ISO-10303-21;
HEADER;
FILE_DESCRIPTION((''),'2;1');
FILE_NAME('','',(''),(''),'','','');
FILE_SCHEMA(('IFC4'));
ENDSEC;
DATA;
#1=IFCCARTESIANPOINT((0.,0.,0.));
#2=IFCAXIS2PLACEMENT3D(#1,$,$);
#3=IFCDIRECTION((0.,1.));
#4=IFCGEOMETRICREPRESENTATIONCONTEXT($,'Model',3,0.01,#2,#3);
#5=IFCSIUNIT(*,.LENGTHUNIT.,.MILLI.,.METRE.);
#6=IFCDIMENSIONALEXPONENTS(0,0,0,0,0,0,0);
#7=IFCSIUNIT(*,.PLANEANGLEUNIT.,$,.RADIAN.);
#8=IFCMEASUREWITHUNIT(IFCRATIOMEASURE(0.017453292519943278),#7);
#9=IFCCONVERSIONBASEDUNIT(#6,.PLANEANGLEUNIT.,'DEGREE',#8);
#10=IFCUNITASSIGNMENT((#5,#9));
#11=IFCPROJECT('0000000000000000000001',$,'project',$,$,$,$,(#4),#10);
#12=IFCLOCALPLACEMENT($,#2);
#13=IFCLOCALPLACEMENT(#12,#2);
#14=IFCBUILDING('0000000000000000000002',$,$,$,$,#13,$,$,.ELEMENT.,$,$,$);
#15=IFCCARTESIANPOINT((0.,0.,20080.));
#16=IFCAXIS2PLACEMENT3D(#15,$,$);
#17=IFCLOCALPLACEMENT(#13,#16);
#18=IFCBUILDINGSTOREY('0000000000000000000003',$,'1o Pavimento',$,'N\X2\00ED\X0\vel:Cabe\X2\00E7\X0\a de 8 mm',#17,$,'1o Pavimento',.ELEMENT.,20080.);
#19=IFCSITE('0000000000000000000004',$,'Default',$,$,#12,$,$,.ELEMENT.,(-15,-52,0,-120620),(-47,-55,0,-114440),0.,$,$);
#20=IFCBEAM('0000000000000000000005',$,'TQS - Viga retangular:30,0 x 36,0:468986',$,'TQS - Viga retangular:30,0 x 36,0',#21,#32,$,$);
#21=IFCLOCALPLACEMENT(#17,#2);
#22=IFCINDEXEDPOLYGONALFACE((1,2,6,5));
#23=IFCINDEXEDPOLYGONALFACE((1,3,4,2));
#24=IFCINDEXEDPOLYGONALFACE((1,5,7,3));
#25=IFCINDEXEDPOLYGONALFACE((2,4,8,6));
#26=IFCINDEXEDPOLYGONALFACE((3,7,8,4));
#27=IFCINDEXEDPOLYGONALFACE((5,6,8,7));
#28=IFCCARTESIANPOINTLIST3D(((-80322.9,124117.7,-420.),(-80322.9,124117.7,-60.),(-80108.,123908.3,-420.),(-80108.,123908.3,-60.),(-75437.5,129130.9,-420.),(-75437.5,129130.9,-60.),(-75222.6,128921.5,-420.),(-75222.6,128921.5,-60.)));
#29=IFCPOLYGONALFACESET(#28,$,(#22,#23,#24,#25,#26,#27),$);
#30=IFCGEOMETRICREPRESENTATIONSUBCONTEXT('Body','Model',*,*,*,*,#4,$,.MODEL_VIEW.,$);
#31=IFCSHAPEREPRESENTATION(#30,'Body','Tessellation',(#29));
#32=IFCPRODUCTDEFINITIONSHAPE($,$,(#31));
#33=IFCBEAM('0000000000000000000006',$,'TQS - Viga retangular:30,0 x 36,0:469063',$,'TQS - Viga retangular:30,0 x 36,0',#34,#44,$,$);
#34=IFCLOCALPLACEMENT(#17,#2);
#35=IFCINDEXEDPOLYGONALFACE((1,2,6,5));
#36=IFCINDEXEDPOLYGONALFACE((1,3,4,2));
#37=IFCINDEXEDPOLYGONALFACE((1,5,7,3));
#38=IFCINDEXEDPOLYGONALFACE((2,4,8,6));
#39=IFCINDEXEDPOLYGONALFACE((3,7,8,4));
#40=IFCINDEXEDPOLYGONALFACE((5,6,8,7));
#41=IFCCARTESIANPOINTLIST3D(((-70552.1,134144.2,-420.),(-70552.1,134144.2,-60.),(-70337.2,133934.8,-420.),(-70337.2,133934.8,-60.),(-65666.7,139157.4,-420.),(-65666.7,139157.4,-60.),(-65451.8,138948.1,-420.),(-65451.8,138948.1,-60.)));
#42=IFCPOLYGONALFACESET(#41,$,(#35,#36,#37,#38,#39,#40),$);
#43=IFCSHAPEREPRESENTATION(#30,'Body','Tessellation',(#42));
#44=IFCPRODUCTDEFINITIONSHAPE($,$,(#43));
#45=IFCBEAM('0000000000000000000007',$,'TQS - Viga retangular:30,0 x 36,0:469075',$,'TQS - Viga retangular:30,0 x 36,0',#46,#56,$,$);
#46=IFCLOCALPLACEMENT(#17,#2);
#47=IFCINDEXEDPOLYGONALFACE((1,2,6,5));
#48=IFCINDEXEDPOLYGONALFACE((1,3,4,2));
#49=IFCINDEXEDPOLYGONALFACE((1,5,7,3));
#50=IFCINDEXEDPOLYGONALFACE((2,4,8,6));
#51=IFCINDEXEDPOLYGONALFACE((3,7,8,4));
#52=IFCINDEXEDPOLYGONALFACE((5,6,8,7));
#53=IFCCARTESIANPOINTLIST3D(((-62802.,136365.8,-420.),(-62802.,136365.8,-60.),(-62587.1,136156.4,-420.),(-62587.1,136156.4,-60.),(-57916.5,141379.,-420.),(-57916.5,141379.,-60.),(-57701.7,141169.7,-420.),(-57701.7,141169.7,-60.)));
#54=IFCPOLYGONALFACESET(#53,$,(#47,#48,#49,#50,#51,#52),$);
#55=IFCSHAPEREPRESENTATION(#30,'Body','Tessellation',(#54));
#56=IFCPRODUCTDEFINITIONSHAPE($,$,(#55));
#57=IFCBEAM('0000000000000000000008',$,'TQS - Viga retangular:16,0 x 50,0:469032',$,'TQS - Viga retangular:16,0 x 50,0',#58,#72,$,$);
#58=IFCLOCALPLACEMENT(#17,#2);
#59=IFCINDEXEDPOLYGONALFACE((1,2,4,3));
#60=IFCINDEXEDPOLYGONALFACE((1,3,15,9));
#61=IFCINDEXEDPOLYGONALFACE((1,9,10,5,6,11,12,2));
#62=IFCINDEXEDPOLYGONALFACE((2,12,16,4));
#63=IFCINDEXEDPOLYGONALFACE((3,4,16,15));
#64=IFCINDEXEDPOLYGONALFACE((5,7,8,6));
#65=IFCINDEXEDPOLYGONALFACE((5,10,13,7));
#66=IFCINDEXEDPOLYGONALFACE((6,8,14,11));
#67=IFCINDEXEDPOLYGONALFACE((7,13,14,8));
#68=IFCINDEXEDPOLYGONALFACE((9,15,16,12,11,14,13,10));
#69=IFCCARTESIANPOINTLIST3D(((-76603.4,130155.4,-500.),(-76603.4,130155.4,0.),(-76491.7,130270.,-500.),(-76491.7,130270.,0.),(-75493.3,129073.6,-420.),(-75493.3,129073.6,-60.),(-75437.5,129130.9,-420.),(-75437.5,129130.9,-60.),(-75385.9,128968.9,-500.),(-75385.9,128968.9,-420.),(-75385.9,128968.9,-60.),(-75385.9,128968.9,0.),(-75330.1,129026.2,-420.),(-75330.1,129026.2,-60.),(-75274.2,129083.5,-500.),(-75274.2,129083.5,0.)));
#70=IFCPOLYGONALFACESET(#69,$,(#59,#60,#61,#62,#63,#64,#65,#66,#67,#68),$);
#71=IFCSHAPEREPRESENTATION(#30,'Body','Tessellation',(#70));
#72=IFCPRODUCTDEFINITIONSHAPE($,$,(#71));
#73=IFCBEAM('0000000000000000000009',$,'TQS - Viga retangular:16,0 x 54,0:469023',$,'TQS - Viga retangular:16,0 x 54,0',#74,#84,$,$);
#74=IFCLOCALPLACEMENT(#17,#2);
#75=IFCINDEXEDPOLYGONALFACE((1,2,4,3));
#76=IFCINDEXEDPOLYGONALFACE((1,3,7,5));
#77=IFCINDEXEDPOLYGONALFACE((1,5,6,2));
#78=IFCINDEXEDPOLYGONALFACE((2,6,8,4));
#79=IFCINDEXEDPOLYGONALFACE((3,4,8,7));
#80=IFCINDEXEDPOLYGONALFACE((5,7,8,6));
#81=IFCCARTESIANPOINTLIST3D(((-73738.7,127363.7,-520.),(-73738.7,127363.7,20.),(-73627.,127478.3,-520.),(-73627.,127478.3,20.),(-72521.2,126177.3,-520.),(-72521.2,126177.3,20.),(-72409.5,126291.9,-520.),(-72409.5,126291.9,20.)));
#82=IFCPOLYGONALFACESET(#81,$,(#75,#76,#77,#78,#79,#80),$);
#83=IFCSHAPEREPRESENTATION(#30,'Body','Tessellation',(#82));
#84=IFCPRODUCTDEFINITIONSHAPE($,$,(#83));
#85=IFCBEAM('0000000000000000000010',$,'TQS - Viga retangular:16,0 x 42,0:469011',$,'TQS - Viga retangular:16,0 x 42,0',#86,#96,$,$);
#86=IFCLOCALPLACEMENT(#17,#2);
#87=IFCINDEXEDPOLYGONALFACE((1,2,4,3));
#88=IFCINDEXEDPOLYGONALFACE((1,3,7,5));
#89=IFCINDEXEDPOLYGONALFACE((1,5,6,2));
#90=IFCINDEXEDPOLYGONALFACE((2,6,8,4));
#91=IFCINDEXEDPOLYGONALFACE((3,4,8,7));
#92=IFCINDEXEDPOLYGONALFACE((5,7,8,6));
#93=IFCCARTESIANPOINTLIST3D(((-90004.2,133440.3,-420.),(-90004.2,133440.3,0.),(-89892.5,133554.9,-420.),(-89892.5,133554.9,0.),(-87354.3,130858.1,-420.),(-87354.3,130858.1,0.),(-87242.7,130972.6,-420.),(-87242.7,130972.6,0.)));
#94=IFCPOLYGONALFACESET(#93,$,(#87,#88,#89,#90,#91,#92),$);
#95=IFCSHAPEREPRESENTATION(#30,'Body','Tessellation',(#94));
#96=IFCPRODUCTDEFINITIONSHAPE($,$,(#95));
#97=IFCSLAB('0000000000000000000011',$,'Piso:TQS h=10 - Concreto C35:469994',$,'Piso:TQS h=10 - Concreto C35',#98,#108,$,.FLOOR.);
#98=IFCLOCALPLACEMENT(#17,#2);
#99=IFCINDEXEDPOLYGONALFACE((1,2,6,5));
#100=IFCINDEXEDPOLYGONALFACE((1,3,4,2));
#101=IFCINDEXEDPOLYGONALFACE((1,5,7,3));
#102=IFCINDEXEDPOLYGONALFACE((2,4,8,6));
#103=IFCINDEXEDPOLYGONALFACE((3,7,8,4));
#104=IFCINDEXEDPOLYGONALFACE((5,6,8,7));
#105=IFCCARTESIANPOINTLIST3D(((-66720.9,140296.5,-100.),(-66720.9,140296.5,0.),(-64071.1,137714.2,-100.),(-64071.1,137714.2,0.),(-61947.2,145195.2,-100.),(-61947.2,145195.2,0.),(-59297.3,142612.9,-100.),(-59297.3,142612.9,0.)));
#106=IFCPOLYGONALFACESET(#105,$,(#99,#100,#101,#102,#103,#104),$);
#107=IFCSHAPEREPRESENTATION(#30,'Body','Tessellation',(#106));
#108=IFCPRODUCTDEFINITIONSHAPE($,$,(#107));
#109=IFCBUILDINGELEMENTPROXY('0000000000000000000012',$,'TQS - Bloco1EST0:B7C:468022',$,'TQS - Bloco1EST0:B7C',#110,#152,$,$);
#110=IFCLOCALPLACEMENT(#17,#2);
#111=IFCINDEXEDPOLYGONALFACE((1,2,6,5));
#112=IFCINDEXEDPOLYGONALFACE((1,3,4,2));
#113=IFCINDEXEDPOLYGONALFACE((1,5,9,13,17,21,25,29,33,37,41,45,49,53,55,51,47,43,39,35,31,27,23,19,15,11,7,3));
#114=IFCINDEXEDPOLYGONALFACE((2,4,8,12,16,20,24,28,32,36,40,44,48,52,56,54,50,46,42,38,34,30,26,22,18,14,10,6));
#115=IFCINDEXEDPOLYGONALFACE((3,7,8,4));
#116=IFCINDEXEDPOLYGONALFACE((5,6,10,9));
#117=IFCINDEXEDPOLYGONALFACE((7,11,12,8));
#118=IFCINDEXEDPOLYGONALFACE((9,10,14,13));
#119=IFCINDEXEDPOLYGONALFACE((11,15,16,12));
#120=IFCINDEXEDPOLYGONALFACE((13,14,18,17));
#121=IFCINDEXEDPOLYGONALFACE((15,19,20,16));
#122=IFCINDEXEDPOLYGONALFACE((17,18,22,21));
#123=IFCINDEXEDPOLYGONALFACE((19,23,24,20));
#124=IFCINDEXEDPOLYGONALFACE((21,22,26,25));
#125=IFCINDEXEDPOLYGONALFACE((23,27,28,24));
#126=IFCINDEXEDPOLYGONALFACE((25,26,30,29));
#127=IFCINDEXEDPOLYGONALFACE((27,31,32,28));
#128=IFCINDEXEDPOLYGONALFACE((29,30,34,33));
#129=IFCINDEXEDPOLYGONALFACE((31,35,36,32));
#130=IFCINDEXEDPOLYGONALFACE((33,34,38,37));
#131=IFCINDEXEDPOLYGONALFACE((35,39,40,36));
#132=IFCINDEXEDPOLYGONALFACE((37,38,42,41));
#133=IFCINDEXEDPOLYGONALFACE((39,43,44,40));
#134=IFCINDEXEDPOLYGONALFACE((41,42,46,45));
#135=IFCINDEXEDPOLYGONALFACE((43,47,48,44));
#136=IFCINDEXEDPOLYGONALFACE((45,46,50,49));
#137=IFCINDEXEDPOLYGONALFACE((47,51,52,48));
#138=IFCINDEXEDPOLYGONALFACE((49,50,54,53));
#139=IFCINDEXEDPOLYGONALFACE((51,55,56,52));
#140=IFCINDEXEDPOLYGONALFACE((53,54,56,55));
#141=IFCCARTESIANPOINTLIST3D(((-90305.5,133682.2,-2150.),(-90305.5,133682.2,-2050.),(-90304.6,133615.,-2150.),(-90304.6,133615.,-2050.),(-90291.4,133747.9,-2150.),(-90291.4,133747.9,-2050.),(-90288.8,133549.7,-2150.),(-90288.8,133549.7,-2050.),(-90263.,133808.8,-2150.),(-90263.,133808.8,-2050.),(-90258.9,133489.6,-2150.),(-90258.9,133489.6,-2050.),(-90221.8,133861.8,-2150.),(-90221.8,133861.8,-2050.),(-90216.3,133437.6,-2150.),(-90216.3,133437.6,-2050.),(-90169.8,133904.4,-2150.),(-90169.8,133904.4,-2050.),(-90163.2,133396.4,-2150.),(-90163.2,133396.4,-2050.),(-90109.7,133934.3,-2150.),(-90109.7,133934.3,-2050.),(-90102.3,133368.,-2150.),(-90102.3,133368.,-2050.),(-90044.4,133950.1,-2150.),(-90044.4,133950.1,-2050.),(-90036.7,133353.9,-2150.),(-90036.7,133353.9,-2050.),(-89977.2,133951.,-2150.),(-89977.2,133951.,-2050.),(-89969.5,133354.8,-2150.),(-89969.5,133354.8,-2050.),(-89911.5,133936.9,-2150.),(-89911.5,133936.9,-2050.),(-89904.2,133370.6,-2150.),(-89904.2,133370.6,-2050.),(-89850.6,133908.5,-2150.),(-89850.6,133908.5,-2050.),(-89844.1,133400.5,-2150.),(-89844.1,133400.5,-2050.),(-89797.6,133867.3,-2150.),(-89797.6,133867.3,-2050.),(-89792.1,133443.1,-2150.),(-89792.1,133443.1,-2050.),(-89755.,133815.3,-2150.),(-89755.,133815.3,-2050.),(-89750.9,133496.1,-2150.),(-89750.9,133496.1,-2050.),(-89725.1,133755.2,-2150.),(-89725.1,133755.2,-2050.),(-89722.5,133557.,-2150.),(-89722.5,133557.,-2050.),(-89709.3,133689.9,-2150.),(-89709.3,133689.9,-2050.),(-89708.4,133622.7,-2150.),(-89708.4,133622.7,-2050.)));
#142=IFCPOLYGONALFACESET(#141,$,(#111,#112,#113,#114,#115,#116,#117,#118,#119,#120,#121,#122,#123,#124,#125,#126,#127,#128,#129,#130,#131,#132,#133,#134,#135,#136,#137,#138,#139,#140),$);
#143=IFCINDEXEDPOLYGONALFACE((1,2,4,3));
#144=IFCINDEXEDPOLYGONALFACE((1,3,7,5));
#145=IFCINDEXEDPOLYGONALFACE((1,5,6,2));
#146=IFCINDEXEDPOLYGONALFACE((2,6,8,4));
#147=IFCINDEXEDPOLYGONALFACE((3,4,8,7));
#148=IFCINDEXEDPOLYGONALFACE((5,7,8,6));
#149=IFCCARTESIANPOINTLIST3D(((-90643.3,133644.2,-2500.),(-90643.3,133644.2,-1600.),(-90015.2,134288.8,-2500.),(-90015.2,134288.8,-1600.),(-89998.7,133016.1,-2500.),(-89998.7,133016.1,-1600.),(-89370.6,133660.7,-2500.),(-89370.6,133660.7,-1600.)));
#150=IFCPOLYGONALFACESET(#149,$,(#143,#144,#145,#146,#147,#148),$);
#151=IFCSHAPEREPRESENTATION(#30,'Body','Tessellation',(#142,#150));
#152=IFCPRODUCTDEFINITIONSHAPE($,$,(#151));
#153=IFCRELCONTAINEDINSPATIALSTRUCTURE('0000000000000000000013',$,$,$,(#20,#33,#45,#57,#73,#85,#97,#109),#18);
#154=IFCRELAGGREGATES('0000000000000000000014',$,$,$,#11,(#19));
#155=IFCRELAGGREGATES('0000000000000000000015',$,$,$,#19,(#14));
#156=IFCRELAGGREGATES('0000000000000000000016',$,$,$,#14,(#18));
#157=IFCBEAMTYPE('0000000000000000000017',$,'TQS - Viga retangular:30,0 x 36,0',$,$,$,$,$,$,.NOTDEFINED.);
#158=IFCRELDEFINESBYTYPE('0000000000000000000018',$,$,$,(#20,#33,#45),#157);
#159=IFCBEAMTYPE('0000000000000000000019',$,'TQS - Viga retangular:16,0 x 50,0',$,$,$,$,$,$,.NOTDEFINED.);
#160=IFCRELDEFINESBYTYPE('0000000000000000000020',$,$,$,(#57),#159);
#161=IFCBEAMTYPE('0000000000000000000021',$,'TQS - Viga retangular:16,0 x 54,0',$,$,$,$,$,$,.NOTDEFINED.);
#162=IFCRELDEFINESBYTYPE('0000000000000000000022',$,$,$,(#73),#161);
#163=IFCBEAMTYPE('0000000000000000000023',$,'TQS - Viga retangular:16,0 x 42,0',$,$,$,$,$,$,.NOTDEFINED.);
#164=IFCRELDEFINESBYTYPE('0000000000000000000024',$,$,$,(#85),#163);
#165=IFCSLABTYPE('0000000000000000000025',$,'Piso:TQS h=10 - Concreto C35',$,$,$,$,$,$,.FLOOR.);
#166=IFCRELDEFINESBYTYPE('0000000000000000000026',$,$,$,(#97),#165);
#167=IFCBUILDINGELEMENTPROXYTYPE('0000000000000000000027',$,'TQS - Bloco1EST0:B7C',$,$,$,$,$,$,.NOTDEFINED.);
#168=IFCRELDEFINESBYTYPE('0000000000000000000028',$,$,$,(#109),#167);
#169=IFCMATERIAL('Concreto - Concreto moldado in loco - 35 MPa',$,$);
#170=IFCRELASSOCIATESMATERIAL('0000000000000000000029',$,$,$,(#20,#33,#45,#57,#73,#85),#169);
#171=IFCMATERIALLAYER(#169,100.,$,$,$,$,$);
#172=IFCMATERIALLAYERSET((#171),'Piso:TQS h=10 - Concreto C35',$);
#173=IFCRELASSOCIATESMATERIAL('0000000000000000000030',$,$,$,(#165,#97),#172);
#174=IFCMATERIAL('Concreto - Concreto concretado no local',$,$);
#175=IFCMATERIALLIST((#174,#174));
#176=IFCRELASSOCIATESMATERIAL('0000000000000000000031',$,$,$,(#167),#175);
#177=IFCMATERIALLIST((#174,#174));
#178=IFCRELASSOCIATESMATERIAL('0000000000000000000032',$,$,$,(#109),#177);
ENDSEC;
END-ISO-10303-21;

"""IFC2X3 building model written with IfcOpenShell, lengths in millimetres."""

from ifc_helpers import new_model, entity, si_unit, converted_unit, direction, frame, frame_2d, origin, origin_2d_with_axis, place, context, subcontext, project, spatial, polyline, rectangle, circle, extrude, boolean, clip, bounded_halfspace, source, transform, mapped, material, material_list, layer, layer_set, layer_usage, type_object, type_shapes, element, save


model = new_model("IFC2X3")

# Units and contexts
model_context = context("Model", 3, precision=0.01, world=origin(), true_north=direction((0.0, 1.0)))
body_context = subcontext(model_context, "Body", "Model", "MODEL_VIEW")
ifc_project = project(units=[si_unit("LENGTHUNIT", "METRE", prefix="MILLI"), converted_unit("PLANEANGLEUNIT", "DEGREE", entity("IfcRatioMeasure", 0.017453292519943278), si_unit("PLANEANGLEUNIT", "RADIAN"), dimensions=[0, 0, 0, 0, 0, 0, 0])], contexts=[model_context])

# Site, building, storey
site_placement = place(None, origin())
site = spatial("IfcSite", under=ifc_project, at=site_placement, Name="Default", CompositionType="ELEMENT", RefLatitude=(-15, -52, 0, -120620), RefLongitude=(-47, -55, 0, -114440), RefElevation=0.0)
building_placement = place(site_placement, origin())
building = spatial("IfcBuilding", under=site, at=building_placement, CompositionType="ELEMENT")
storey_placement = place(building_placement, frame((0.0, 0.0, 20080.0)))
storey = spatial("IfcBuildingStorey", under=building, at=storey_placement, Name="1o Pavimento", ObjectType="Nível:Cabeça de 8 mm", LongName="1o Pavimento", CompositionType="ELEMENT", Elevation=20080.0)

# Beams
ifc_material_1 = material(Name="Concreto - Concreto moldado in loco - 35 MPa")
beam_type_1 = type_object("IfcBeamType", Name="TQS - Viga retangular:30,0 x 36,0", PredefinedType="NOTDEFINED")
beam_1_placement = place(storey_placement, frame((-80215.5, 124013.0, -60.0), z_axis=(0.0, 0.0, 1.0), x_axis=(0.697915, 0.71618, 0.0)))
element("IfcBeam", 1, at=beam_1_placement, inside=storey, type_object=beam_type_1, material=ifc_material_1, Name="TQS - Viga retangular:30,0 x 36,0:468986", ObjectType="TQS - Viga retangular:30,0 x 36,0", context=body_context, shape_type="SweptSolid", body=[
    extrude(rectangle(XDim=360.0, YDim=300.0, at=frame_2d((0.0, 0.0), x_axis=(1.0, 0.0))), frame((0.0, 0.0, -180.0), z_axis=(1.0, 0.0, 0.0), x_axis=(0.0, 0.0, -1.0)), (0.0, 0.0, 1.0), 7000.0),
])
beam_2_placement = place(storey_placement, frame((-70444.7, 134039.5, -60.0), z_axis=(0.0, 0.0, 1.0), x_axis=(0.697915, 0.71618, 0.0)))
element("IfcBeam", 2, at=beam_2_placement, inside=storey, type_object=beam_type_1, material=ifc_material_1, Name="TQS - Viga retangular:30,0 x 36,0:469063", ObjectType="TQS - Viga retangular:30,0 x 36,0", context=body_context, shape_type="SweptSolid", body=[
    extrude(rectangle(XDim=360.0, YDim=300.0, at=frame_2d((0.0, 0.0), x_axis=(1.0, 0.0))), frame((0.0, 0.0, -180.0), z_axis=(1.0, 0.0, 0.0), x_axis=(0.0, 0.0, -1.0)), (0.0, 0.0, 1.0), 7000.0),
])
beam_3_placement = place(storey_placement, frame((-62694.5, 136261.1, -60.0), z_axis=(0.0, 0.0, 1.0), x_axis=(0.697915, 0.71618, 0.0)))
element("IfcBeam", 3, at=beam_3_placement, inside=storey, type_object=beam_type_1, material=ifc_material_1, Name="TQS - Viga retangular:30,0 x 36,0:469075", ObjectType="TQS - Viga retangular:30,0 x 36,0", context=body_context, shape_type="SweptSolid", body=[
    extrude(rectangle(XDim=360.0, YDim=300.0, at=frame_2d((0.0, 0.0), x_axis=(1.0, 0.0))), frame((0.0, 0.0, -180.0), z_axis=(1.0, 0.0, 0.0), x_axis=(0.0, 0.0, -1.0)), (0.0, 0.0, 1.0), 7000.0),
])
beam_type_2 = type_object("IfcBeamType", Name="TQS - Viga retangular:16,0 x 50,0", PredefinedType="NOTDEFINED")
beam_4_placement = place(storey_placement, frame((-75330.1, 129026.2, 0.0), z_axis=(0.0, 0.0, 1.0), x_axis=(-0.71618, 0.697915, 0.0)))
element("IfcBeam", 4, at=beam_4_placement, inside=storey, type_object=beam_type_2, material=ifc_material_1, Name="TQS - Viga retangular:16,0 x 50,0:469032", ObjectType="TQS - Viga retangular:16,0 x 50,0", context=body_context, shape_type="SweptSolid", body=[
    boolean("DIFFERENCE", clip(extrude(rectangle(XDim=500.0, YDim=160.0, at=frame_2d((0.0, 0.0), x_axis=(1.0, 0.0))), frame((0.0, 0.0, -250.0), z_axis=(1.0, 0.0, 0.0), x_axis=(0.0, 0.0, -1.0)), (0.0, 0.0, 1.0), 1700.0), bounded_halfspace(frame((150.0, 0.0, -420.0), z_axis=(-1.0, 0.0, 0.0), x_axis=(0.0, 1.0, 0.0)), False, frame((0.0, 0.0, -250.0), z_axis=(1.0, 0.0, 0.0), x_axis=(0.0, 0.0, -1.0)), polyline([(170.0, 0.0), (-190.0, 0.0), (-190.0, 80.0), (-90.0, 80.0), (170.0, 80.0), (170.0, 0.0)]))), extrude(rectangle(XDim=360.0, YDim=80.0, at=frame_2d((0.0, 0.0), x_axis=(0.0, 1.0))), frame((0.0, 40.0, -240.0), z_axis=(-1.0, 0.0, 0.0), x_axis=(0.0, -1.0, 0.0)), (0.0, 0.0, -1.0), 150.0)),
])
beam_type_3 = type_object("IfcBeamType", Name="TQS - Viga retangular:16,0 x 54,0", PredefinedType="NOTDEFINED")
beam_5_placement = place(storey_placement, frame((-72465.3, 126234.6, 20.0), z_axis=(0.0, 0.0, 1.0), x_axis=(-0.71618, 0.697915, 0.0)))
element("IfcBeam", 5, at=beam_5_placement, inside=storey, type_object=beam_type_3, material=ifc_material_1, Name="TQS - Viga retangular:16,0 x 54,0:469023", ObjectType="TQS - Viga retangular:16,0 x 54,0", context=body_context, shape_type="SweptSolid", body=[
    extrude(rectangle(XDim=540.0, YDim=160.0, at=frame_2d((0.0, 0.0), x_axis=(1.0, 0.0))), frame((0.0, 0.0, -270.0), z_axis=(1.0, 0.0, 0.0), x_axis=(0.0, 0.0, -1.0)), (0.0, 0.0, 1.0), 1700.0),
])
beam_type_4 = type_object("IfcBeamType", Name="TQS - Viga retangular:16,0 x 42,0", PredefinedType="NOTDEFINED")
beam_6_placement = place(storey_placement, frame((-87241.2, 130859.5, 0.0), z_axis=(0.0, 0.0, 1.0), x_axis=(-0.71618, 0.697915, 0.0)))
element("IfcBeam", 6, at=beam_6_placement, inside=storey, type_object=beam_type_4, material=ifc_material_1, Name="TQS - Viga retangular:16,0 x 42,0:469011", ObjectType="TQS - Viga retangular:16,0 x 42,0", context=body_context, shape_type="SweptSolid", body=[
    extrude(rectangle(XDim=420.0, YDim=160.0, at=frame_2d((0.0, 0.0), x_axis=(1.0, 0.0))), frame((80.0, 0.0, -210.0), z_axis=(1.0, 0.0, 0.0), x_axis=(0.0, 0.0, -1.0)), (0.0, 0.0, 1.0), 3700.0),
])

# Slab
ifc_layer = layer(ifc_material_1, 100.0)
ifc_layer_set = layer_set([ifc_layer], Name="Piso:TQS h=10 - Concreto C35")
ifc_layer_usage_1 = layer_usage(ifc_layer_set, "AXIS3", "POSITIVE", 0.0)
slab_type_1 = type_object("IfcSlabType", Name="Piso:TQS h=10 - Concreto C35", PredefinedType="FLOOR", material=ifc_layer_set)
slab_1_placement = place(storey_placement, origin())
element("IfcSlab", 7, at=slab_1_placement, inside=storey, type_object=slab_type_1, material=ifc_layer_usage_1, Name="Piso:TQS h=10 - Concreto C35:469994", ObjectType="Piso:TQS h=10 - Concreto C35", PredefinedType="FLOOR", context=body_context, shape_type="SweptSolid", body=[
    extrude(rectangle(XDim=6840.0, YDim=3700.0, at=frame_2d((0.0, 0.0), x_axis=(1.0, 0.0))), frame((-63009.1, 141454.7, 0.0), z_axis=(0.0, 0.0, -1.0), x_axis=(-0.697915, -0.71618, 0.0)), (0.0, 0.0, 1.0), 100.0),
])

# Building element proxy
ifc_material_2 = material(Name="Concreto - Concreto concretado no local")
ifc_material_list_1 = material_list([ifc_material_2, ifc_material_2])
ifc_material_list_2 = material_list([ifc_material_2, ifc_material_2])
building_element_proxy_type_1 = type_object("IfcBuildingElementProxyType", Name="TQS - Bloco1EST0:B7C", PredefinedType="NOTDEFINED", material=ifc_material_list_2)
shared_shape_1 = source(origin(), body_context, "Body", "SweptSolid", [
    extrude(circle(Radius=300.0, at=frame_2d((0.0, 0.0), x_axis=(1.0, 0.0))), frame((0.0, 0.0, -550.0)), (0.0, 0.0, 1.0), 100.0),
    extrude(rectangle(XDim=900.0, YDim=900.0, at=origin_2d_with_axis()), frame((0.0, 0.0, -900.0), z_axis=(0.0, 0.0, 1.0), x_axis=(-1.0, 0.0, 0.0)), (0.0, 0.0, 1.0), 900.0),
])
type_shapes(building_element_proxy_type_1, [shared_shape_1])
proxy_1_placement = place(storey_placement, frame((-90006.9, 133652.5, -1600.0), z_axis=(0.0, 0.0, 1.0), x_axis=(0.697915, 0.71618, 0.0)))
element("IfcBuildingElementProxy", 8, at=proxy_1_placement, inside=storey, type_object=building_element_proxy_type_1, material=ifc_material_list_1, Name="TQS - Bloco1EST0:B7C:468022", ObjectType="TQS - Bloco1EST0:B7C", context=body_context, shape_type="MappedRepresentation", body=[
    mapped(shared_shape_1, transform((0.0, 0.0, 0.0), scale=1.0)),
])

save(model, "model.ifc")
